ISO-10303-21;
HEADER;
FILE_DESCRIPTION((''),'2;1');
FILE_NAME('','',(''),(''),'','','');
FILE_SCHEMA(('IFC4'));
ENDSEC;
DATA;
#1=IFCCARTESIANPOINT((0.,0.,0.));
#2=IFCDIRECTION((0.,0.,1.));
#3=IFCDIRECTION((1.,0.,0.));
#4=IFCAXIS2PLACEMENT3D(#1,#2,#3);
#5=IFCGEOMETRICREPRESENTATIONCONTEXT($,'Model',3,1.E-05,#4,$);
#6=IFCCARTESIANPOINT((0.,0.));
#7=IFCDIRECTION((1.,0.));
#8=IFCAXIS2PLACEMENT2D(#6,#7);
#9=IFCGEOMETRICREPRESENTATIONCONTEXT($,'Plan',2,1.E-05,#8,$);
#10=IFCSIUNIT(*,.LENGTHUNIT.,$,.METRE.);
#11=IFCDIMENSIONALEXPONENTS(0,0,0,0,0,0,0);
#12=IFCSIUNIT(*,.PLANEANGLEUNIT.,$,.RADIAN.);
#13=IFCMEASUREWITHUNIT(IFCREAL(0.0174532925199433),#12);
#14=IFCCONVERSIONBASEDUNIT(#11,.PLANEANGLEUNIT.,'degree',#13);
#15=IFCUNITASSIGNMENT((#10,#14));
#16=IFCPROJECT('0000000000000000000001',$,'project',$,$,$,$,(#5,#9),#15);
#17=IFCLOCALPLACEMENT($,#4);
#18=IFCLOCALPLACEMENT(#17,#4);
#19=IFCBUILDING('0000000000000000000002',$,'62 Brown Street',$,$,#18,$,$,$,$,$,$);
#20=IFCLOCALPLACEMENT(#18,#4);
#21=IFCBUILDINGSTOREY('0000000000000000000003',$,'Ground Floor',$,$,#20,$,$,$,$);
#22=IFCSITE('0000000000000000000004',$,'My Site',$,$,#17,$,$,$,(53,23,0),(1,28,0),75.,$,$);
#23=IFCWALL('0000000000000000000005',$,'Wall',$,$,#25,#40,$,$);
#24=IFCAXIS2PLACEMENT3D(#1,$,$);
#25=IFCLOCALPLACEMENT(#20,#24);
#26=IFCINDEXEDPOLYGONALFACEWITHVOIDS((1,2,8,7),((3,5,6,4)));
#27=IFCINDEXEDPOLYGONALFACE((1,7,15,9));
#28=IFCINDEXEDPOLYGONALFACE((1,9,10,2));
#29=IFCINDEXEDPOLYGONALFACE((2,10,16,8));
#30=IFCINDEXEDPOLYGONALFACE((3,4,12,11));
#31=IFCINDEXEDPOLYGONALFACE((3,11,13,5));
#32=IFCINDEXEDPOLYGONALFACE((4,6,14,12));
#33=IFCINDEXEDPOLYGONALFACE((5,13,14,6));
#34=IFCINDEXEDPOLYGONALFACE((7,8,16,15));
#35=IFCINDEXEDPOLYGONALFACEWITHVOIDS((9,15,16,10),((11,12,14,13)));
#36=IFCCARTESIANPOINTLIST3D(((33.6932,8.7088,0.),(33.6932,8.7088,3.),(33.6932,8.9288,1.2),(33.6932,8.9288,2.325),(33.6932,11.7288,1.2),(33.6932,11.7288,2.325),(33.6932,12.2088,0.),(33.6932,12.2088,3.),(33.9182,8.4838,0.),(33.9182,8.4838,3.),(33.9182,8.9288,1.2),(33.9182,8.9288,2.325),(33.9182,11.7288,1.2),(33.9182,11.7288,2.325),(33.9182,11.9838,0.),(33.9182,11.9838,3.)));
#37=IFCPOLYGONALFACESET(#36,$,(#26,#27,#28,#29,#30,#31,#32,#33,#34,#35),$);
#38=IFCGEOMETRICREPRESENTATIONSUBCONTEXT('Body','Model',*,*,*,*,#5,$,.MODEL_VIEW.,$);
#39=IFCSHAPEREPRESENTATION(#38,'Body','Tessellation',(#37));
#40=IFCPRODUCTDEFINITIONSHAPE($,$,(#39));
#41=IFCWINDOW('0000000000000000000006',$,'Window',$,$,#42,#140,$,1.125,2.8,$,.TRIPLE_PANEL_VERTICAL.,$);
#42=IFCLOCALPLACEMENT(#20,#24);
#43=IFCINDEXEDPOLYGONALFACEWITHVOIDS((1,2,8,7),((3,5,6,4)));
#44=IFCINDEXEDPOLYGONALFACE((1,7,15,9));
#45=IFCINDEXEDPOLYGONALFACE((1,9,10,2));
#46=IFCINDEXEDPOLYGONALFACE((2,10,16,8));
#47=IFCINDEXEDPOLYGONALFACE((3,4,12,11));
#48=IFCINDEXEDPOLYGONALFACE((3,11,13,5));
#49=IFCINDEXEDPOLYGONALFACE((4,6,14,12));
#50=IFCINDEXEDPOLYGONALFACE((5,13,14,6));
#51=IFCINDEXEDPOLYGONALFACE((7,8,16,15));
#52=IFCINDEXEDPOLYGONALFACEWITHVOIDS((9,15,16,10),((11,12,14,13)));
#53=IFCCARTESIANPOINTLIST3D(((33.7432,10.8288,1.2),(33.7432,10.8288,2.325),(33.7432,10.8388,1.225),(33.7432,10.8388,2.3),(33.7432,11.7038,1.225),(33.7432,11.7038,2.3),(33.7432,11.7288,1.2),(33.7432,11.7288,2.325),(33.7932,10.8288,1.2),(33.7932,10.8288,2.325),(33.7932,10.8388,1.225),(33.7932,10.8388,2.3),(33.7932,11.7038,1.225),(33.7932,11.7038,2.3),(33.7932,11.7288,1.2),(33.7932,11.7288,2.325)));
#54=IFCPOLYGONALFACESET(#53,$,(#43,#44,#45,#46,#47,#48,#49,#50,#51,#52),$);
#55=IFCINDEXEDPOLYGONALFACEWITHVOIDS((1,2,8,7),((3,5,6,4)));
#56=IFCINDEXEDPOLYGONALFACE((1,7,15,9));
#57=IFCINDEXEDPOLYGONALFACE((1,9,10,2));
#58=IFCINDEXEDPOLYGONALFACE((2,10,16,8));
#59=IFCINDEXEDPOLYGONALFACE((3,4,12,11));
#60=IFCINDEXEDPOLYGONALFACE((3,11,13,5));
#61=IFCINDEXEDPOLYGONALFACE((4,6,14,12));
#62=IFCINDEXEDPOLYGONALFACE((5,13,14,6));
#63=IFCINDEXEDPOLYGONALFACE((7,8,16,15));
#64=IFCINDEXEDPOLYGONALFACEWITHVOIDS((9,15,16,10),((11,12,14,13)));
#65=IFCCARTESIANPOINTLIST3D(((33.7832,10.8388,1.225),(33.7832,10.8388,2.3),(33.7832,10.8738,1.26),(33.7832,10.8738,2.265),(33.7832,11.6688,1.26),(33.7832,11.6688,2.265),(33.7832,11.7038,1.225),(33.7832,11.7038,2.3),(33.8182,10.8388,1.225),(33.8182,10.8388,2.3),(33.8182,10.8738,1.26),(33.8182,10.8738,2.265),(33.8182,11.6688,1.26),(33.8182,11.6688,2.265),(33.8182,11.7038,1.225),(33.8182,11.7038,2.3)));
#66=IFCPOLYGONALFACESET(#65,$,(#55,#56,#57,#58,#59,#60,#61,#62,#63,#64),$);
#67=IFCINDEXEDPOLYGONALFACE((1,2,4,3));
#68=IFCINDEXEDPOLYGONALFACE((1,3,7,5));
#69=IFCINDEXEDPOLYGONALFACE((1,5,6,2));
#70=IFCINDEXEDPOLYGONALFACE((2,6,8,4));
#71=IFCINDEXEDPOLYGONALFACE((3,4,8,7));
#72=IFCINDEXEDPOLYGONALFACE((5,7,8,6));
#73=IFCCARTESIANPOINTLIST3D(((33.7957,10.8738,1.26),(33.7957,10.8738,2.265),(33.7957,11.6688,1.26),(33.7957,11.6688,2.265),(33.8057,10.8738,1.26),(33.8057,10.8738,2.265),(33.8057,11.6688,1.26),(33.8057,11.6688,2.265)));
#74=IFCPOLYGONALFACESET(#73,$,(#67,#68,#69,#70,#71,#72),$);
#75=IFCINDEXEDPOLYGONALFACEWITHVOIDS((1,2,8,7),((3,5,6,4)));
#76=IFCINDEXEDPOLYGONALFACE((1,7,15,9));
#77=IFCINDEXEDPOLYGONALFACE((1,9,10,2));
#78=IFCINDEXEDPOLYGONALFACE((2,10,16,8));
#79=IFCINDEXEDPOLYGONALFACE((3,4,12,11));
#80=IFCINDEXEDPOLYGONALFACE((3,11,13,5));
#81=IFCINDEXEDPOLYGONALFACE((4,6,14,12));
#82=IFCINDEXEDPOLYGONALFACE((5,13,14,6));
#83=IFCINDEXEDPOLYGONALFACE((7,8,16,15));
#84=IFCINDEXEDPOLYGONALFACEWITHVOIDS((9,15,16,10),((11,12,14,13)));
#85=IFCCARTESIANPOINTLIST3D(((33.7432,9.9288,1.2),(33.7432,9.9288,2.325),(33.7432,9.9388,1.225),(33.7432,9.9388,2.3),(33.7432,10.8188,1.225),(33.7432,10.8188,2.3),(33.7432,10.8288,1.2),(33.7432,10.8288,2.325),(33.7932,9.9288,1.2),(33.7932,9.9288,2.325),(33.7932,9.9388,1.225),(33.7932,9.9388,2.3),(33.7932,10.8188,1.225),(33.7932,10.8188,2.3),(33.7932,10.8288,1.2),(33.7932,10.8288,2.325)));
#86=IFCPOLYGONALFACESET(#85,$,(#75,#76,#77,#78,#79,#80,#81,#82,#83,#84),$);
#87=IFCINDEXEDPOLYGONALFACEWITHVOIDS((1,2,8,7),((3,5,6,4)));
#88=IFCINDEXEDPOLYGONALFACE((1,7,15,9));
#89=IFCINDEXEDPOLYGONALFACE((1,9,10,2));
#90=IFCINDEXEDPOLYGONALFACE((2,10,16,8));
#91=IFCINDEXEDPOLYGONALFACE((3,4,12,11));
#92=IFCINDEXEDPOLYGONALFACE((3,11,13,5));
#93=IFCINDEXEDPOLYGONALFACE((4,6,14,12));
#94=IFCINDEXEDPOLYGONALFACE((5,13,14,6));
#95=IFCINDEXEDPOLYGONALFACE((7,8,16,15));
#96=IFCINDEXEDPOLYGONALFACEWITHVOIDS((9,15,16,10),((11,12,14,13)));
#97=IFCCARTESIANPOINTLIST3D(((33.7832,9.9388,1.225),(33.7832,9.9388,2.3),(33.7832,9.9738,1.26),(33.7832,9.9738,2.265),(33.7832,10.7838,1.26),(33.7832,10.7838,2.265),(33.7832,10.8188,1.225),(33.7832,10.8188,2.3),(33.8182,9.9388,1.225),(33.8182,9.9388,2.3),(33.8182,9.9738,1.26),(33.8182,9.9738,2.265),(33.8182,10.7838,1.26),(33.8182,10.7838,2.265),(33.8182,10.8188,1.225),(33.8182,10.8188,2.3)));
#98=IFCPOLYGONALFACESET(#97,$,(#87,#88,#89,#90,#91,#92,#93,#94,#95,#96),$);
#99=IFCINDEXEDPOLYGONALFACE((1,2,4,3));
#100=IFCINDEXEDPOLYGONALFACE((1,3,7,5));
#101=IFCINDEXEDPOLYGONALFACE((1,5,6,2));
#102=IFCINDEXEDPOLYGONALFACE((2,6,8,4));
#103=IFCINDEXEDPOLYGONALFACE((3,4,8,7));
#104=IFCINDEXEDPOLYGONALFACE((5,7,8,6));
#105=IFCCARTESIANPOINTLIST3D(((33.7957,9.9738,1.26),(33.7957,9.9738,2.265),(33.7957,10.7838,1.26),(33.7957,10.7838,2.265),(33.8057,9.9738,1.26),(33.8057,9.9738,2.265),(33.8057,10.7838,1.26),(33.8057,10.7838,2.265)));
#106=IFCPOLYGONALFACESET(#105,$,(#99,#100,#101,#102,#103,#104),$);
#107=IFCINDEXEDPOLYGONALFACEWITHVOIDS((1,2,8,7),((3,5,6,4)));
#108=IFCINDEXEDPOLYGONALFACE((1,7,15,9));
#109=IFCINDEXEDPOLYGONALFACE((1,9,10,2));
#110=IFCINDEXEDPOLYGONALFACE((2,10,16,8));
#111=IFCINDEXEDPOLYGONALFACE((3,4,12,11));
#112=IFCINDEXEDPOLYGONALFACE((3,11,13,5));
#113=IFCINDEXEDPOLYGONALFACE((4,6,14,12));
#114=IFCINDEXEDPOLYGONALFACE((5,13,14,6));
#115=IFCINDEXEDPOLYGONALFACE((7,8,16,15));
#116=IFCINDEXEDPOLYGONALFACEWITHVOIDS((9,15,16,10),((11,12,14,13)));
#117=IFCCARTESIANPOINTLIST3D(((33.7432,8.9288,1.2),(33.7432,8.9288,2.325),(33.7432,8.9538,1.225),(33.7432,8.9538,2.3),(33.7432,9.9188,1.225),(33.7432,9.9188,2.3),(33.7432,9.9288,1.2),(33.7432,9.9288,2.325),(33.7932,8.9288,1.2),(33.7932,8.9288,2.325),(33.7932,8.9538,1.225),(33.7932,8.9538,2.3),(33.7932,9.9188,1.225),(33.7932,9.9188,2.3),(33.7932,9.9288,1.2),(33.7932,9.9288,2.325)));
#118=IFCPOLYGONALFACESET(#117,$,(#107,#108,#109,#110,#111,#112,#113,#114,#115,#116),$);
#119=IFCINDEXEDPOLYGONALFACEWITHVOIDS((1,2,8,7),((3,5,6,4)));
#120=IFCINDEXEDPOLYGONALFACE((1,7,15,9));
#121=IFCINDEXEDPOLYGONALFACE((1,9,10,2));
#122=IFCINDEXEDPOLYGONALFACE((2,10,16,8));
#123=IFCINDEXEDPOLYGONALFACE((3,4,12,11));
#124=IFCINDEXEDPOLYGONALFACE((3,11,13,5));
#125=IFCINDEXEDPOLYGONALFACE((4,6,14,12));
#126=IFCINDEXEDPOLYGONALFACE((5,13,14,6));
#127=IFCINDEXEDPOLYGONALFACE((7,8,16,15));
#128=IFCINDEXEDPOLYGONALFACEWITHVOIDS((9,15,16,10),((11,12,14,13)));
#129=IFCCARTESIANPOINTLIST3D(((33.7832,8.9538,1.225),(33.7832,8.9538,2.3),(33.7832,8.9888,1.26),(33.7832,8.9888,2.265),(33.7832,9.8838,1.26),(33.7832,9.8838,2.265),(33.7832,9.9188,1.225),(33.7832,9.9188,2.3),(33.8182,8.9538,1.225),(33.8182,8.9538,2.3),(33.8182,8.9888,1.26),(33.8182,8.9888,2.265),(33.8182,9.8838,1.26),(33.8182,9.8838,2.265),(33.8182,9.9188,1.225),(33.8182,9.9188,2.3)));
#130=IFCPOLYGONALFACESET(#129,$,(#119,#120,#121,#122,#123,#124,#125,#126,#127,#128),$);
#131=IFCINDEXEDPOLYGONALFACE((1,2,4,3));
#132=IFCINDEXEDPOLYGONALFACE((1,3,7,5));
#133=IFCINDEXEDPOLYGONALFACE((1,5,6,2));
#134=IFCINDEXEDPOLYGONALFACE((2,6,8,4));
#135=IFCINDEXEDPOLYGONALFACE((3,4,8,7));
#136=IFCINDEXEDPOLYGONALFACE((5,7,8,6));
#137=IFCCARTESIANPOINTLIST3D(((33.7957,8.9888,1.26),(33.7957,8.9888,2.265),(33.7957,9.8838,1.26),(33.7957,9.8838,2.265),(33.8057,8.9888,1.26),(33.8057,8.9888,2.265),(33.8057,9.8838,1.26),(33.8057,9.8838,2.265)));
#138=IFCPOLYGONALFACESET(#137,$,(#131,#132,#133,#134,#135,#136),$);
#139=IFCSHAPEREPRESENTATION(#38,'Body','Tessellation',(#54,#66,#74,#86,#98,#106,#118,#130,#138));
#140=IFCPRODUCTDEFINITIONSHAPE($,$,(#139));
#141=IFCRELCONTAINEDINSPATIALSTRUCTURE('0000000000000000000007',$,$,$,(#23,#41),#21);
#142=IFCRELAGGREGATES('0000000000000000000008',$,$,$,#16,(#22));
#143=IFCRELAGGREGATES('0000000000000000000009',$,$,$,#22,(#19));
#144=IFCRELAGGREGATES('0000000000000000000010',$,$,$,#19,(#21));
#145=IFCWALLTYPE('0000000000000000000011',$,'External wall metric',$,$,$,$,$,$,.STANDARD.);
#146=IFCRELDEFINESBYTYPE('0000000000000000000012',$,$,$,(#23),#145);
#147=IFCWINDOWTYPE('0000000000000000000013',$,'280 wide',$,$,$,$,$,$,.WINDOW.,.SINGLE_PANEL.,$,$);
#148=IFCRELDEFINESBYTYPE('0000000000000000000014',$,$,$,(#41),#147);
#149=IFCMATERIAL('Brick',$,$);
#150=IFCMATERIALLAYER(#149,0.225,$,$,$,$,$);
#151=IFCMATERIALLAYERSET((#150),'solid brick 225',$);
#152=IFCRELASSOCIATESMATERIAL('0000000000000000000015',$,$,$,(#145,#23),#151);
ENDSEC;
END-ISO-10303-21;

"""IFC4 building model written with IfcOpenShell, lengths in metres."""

from ifc_helpers import new_model, entity, si_unit, converted_unit, frame, origin_with_axes, origin_2d_with_axis, place, context, subcontext, project, spatial, line, indexed_curve, outline, extrude, clip, halfspace, shape, source, transform, mapped, material, layer, layer_set, layer_usage, type_object, type_shapes, element, fill, save


model = new_model("IFC4")

# Units and contexts
model_context = context("Model", 3, precision=1e-05, world=origin_with_axes())
plan_context = context("Plan", 2, precision=1e-05, world=origin_2d_with_axis())
body_context_1 = subcontext(model_context, "Body", "Model", "MODEL_VIEW")
body_context_2 = subcontext(plan_context, "Body", "Plan", "PLAN_VIEW")
ifc_project = project(units=[si_unit("LENGTHUNIT", "METRE"), converted_unit("PLANEANGLEUNIT", "degree", entity("IfcReal", 0.0174532925199433), si_unit("PLANEANGLEUNIT", "RADIAN"), dimensions=[0, 0, 0, 0, 0, 0, 0])], contexts=[model_context, plan_context])

# Site, building, storey
site_placement = place(None, origin_with_axes())
site = spatial("IfcSite", under=ifc_project, at=site_placement, Name="My Site", RefLatitude=(53, 23, 0), RefLongitude=(1, 28, 0), RefElevation=75.0)
building_placement = place(site_placement, origin_with_axes())
building = spatial("IfcBuilding", under=site, at=building_placement, Name="62 Brown Street")
storey_placement = place(building_placement, origin_with_axes())
storey = spatial("IfcBuildingStorey", under=building, at=storey_placement, Name="Ground Floor")

# Wall, opening, window
ifc_material_1 = material(Name="Brick")
ifc_layer_1 = layer(ifc_material_1, 0.225)
ifc_layer_set_1 = layer_set([ifc_layer_1], Name="solid brick 225")
ifc_layer_usage_1 = layer_usage(ifc_layer_set_1, "AXIS2", "POSITIVE", 0.0)
wall_type_1 = type_object("IfcWallType", Name="External wall metric", PredefinedType="STANDARD", material=ifc_layer_set_1)
wall_1_placement = place(storey_placement, frame((33.6932, 12.2088, 0.0), z_axis=(0.0, 0.0, 1.0), x_axis=(0.0, -1.0, 0.0)))
wall_1 = element("IfcWall", 1, at=wall_1_placement, inside=storey, type_object=wall_type_1, material=ifc_layer_usage_1, Name="Wall", context=body_context_1, shape_type="Clipping", body=[
    clip(clip(extrude(outline(indexed_curve([(0.0, 0.0), (0.0, 0.225), (3.725, 0.225), (3.725, 0.0), (0.0, 0.0)], self_intersect=False)), origin_with_axes(), (0.0, 0.0, 1.0), 3.0), halfspace(frame((0.0, 0.0, 0.0), z_axis=(-0.674995, 0.675001, 0.0), x_axis=(0.225, 0.224998, 0.0)), False)), halfspace(frame((3.5, 0.0, 0.0), z_axis=(0.674995, -0.674999, 0.0), x_axis=(0.225, 0.224998, 0.0)), False)),
])
shared_shape_1 = source(origin_with_axes(), body_context_1, "Body", "SweptSolid", [
    extrude(outline(indexed_curve([(0.0, 0.0), (2.8, 0.0), (2.8, 1.125), (0.0, 1.125)], segments=[line(1, 2, 3, 4, 1)])), frame((0.0, -0.1, 0.0), z_axis=(0.0, -1.0, 0.0), x_axis=(1.0, 0.0, 0.0)), (0.0, 0.0, -1.0), 0.425),
])
opening_1_placement = place(wall_1_placement, frame((0.48, 0.0, 1.2), z_axis=(0.0, 0.0, 1.0), x_axis=(1.0, 0.0, 0.0)))
opening_1 = element("IfcOpeningElement", 2, at=opening_1_placement, cuts=wall_1, PredefinedType="OPENING", context=body_context_1, shape_type="MappedRepresentation", body=[
    mapped(shared_shape_1, transform((0.0, 0.0, 0.0), x_axis=(1.0, 0.0, 0.0), y_axis=(0.0, 1.0, 0.0), z_axis=(0.0, 0.0, 1.0), scale=1.0)),
])
window_type_1 = type_object("IfcWindowType", Name="280 wide", PartitioningType="SINGLE_PANEL", PredefinedType="WINDOW")
shared_shape_2 = source(origin_with_axes(), body_context_1, "Body", "SweptSolid", [
    extrude(outline(indexed_curve([(0.0, 0.0), (0.9, 0.0), (0.9, 1.125), (0.0, 1.125)], segments=[line(1, 2, 3, 4, 1)]), holes=[indexed_curve([(0.025, 0.025), (0.89, 0.025), (0.89, 1.1), (0.025, 1.1)], segments=[line(1, 2, 3, 4, 1)])]), frame((0.0, 0.05, 0.0), z_axis=(0.0, -1.0, 0.0), x_axis=(1.0, 0.0, 0.0)), (0.0, 0.0, -1.0), 0.05),
    extrude(outline(indexed_curve([(0.0, 0.0), (0.865, 0.0), (0.865, 1.075), (0.0, 1.075)], segments=[line(1, 2, 3, 4, 1)]), holes=[indexed_curve([(0.035, 0.035), (0.83, 0.035), (0.83, 1.04), (0.035, 1.04)], segments=[line(1, 2, 3, 4, 1)])]), frame((0.025, 0.09, 0.025), z_axis=(0.0, -1.0, 0.0), x_axis=(1.0, 0.0, 0.0)), (0.0, 0.0, -1.0), 0.035),
    extrude(outline(indexed_curve([(0.035, 0.035), (0.83, 0.035), (0.83, 1.04), (0.035, 1.04)], segments=[line(1, 2, 3, 4, 1)])), frame((0.025, 0.1025, 0.025), z_axis=(0.0, -1.0, 0.0), x_axis=(1.0, 0.0, 0.0)), (0.0, 0.0, -1.0), 0.01),
    extrude(outline(indexed_curve([(0.0, 0.0), (0.9, 0.0), (0.9, 1.125), (0.0, 1.125)], segments=[line(1, 2, 3, 4, 1)]), holes=[indexed_curve([(0.01, 0.025), (0.89, 0.025), (0.89, 1.1), (0.01, 1.1)], segments=[line(1, 2, 3, 4, 1)])]), frame((0.9, 0.05, 0.0), z_axis=(0.0, -1.0, 0.0), x_axis=(1.0, 0.0, 0.0)), (0.0, 0.0, -1.0), 0.05),
    extrude(outline(indexed_curve([(0.0, 0.0), (0.88, 0.0), (0.88, 1.075), (0.0, 1.075)], segments=[line(1, 2, 3, 4, 1)]), holes=[indexed_curve([(0.035, 0.035), (0.845, 0.035), (0.845, 1.04), (0.035, 1.04)], segments=[line(1, 2, 3, 4, 1)])]), frame((0.91, 0.09, 0.025), z_axis=(0.0, -1.0, 0.0), x_axis=(1.0, 0.0, 0.0)), (0.0, 0.0, -1.0), 0.035),
    extrude(outline(indexed_curve([(0.035, 0.035), (0.845, 0.035), (0.845, 1.04), (0.035, 1.04)], segments=[line(1, 2, 3, 4, 1)])), frame((0.91, 0.1025, 0.025), z_axis=(0.0, -1.0, 0.0), x_axis=(1.0, 0.0, 0.0)), (0.0, 0.0, -1.0), 0.01),
    extrude(outline(indexed_curve([(0.0, 0.0), (1.0, 0.0), (1.0, 1.125), (0.0, 1.125)], segments=[line(1, 2, 3, 4, 1)]), holes=[indexed_curve([(0.01, 0.025), (0.975, 0.025), (0.975, 1.1), (0.01, 1.1)], segments=[line(1, 2, 3, 4, 1)])]), frame((1.8, 0.05, 0.0), z_axis=(0.0, -1.0, 0.0), x_axis=(1.0, 0.0, 0.0)), (0.0, 0.0, -1.0), 0.05),
    extrude(outline(indexed_curve([(0.0, 0.0), (0.965, 0.0), (0.965, 1.075), (0.0, 1.075)], segments=[line(1, 2, 3, 4, 1)]), holes=[indexed_curve([(0.035, 0.035), (0.93, 0.035), (0.93, 1.04), (0.035, 1.04)], segments=[line(1, 2, 3, 4, 1)])]), frame((1.81, 0.09, 0.025), z_axis=(0.0, -1.0, 0.0), x_axis=(1.0, 0.0, 0.0)), (0.0, 0.0, -1.0), 0.035),
    extrude(outline(indexed_curve([(0.035, 0.035), (0.93, 0.035), (0.93, 1.04), (0.035, 1.04)], segments=[line(1, 2, 3, 4, 1)])), frame((1.81, 0.1025, 0.025), z_axis=(0.0, -1.0, 0.0), x_axis=(1.0, 0.0, 0.0)), (0.0, 0.0, -1.0), 0.01),
])
shared_shape_3 = source(origin_with_axes(), body_context_2, "Body", "Curve2D", [
    entity("IfcIndexedPolyCurve", entity("IfcCartesianPointList2D", [[0.025, 0.05], [0.89, 0.05]])),
    entity("IfcIndexedPolyCurve", entity("IfcCartesianPointList2D", [[0.0, 0.1], [0.025, 0.1], [0.025, 0.05], [0.0, 0.05]]), [entity("IfcLineIndex", [1, 2, 3, 4, 1])]),
    entity("IfcIndexedPolyCurve", entity("IfcCartesianPointList2D", [[0.9, 0.1], [0.89, 0.1], [0.89, 0.05], [0.9, 0.05]])),
    entity("IfcIndexedPolyCurve", entity("IfcCartesianPointList2D", [[0.025, 0.09], [0.06, 0.09], [0.06, 0.125], [0.025, 0.125]]), [entity("IfcLineIndex", [1, 2, 3, 4, 1])]),
    entity("IfcIndexedPolyCurve", entity("IfcCartesianPointList2D", [[0.89, 0.09], [0.855, 0.09], [0.855, 0.125], [0.89, 0.125]]), [entity("IfcLineIndex", [1, 2, 3, 4, 1])]),
    entity("IfcIndexedPolyCurve", entity("IfcCartesianPointList2D", [[0.06, 0.09], [0.855, 0.09]])),
    entity("IfcIndexedPolyCurve", entity("IfcCartesianPointList2D", [[0.06, 0.125], [0.855, 0.125]])),
    entity("IfcIndexedPolyCurve", entity("IfcCartesianPointList2D", [[0.06, 0.1075], [0.855, 0.1075]])),
    entity("IfcIndexedPolyCurve", entity("IfcCartesianPointList2D", [[0.91, 0.05], [1.79, 0.05]])),
    entity("IfcIndexedPolyCurve", entity("IfcCartesianPointList2D", [[0.9, 0.1], [0.91, 0.1], [0.91, 0.05], [0.9, 0.05]])),
    entity("IfcIndexedPolyCurve", entity("IfcCartesianPointList2D", [[1.8, 0.1], [1.79, 0.1], [1.79, 0.05], [1.8, 0.05]])),
    entity("IfcIndexedPolyCurve", entity("IfcCartesianPointList2D", [[0.91, 0.09], [0.945, 0.09], [0.945, 0.125], [0.91, 0.125]]), [entity("IfcLineIndex", [1, 2, 3, 4, 1])]),
    entity("IfcIndexedPolyCurve", entity("IfcCartesianPointList2D", [[1.79, 0.09], [1.755, 0.09], [1.755, 0.125], [1.79, 0.125]]), [entity("IfcLineIndex", [1, 2, 3, 4, 1])]),
    entity("IfcIndexedPolyCurve", entity("IfcCartesianPointList2D", [[0.945, 0.09], [1.755, 0.09]])),
    entity("IfcIndexedPolyCurve", entity("IfcCartesianPointList2D", [[0.945, 0.125], [1.755, 0.125]])),
    entity("IfcIndexedPolyCurve", entity("IfcCartesianPointList2D", [[0.945, 0.1075], [1.755, 0.1075]])),
    entity("IfcIndexedPolyCurve", entity("IfcCartesianPointList2D", [[1.81, 0.05], [2.775, 0.05]])),
    entity("IfcIndexedPolyCurve", entity("IfcCartesianPointList2D", [[1.8, 0.1], [1.81, 0.1], [1.81, 0.05], [1.8, 0.05]])),
    entity("IfcIndexedPolyCurve", entity("IfcCartesianPointList2D", [[2.8, 0.1], [2.775, 0.1], [2.775, 0.05], [2.8, 0.05]]), [entity("IfcLineIndex", [1, 2, 3, 4, 1])]),
    entity("IfcIndexedPolyCurve", entity("IfcCartesianPointList2D", [[1.81, 0.09], [1.845, 0.09], [1.845, 0.125], [1.81, 0.125]]), [entity("IfcLineIndex", [1, 2, 3, 4, 1])]),
    entity("IfcIndexedPolyCurve", entity("IfcCartesianPointList2D", [[2.775, 0.09], [2.74, 0.09], [2.74, 0.125], [2.775, 0.125]]), [entity("IfcLineIndex", [1, 2, 3, 4, 1])]),
    entity("IfcIndexedPolyCurve", entity("IfcCartesianPointList2D", [[1.845, 0.09], [2.74, 0.09]])),
    entity("IfcIndexedPolyCurve", entity("IfcCartesianPointList2D", [[1.845, 0.125], [2.74, 0.125]])),
    entity("IfcIndexedPolyCurve", entity("IfcCartesianPointList2D", [[1.845, 0.1075], [2.74, 0.1075]])),
])
type_shapes(window_type_1, [shared_shape_2, shared_shape_3])
window_1_placement = place(opening_1_placement, frame((0.0, 0.0, 0.0), z_axis=(0.0, 0.0, 1.0), x_axis=(1.0, 0.0, 0.0)))
window_1 = element("IfcWindow", 3, at=window_1_placement, inside=storey, type_object=window_type_1, Name="Window", OverallHeight=1.125, OverallWidth=2.8, PartitioningType="TRIPLE_PANEL_VERTICAL", shapes=[
    shape(body_context_1, "Body", "MappedRepresentation", [mapped(shared_shape_2, transform((0.0, 0.0, 0.0), x_axis=(1.0, 0.0, 0.0), y_axis=(0.0, 1.0, 0.0), z_axis=(0.0, 0.0, 1.0), scale=1.0))]),
    shape(body_context_2, "Body", "MappedRepresentation", [mapped(shared_shape_3, transform((0.0, 0.0, 0.0), x_axis=(1.0, 0.0, 0.0), y_axis=(0.0, 1.0, 0.0), z_axis=(0.0, 0.0, 1.0), scale=1.0))]),
])
fill(opening_1, window_1)

save(model, "model.ifc")
